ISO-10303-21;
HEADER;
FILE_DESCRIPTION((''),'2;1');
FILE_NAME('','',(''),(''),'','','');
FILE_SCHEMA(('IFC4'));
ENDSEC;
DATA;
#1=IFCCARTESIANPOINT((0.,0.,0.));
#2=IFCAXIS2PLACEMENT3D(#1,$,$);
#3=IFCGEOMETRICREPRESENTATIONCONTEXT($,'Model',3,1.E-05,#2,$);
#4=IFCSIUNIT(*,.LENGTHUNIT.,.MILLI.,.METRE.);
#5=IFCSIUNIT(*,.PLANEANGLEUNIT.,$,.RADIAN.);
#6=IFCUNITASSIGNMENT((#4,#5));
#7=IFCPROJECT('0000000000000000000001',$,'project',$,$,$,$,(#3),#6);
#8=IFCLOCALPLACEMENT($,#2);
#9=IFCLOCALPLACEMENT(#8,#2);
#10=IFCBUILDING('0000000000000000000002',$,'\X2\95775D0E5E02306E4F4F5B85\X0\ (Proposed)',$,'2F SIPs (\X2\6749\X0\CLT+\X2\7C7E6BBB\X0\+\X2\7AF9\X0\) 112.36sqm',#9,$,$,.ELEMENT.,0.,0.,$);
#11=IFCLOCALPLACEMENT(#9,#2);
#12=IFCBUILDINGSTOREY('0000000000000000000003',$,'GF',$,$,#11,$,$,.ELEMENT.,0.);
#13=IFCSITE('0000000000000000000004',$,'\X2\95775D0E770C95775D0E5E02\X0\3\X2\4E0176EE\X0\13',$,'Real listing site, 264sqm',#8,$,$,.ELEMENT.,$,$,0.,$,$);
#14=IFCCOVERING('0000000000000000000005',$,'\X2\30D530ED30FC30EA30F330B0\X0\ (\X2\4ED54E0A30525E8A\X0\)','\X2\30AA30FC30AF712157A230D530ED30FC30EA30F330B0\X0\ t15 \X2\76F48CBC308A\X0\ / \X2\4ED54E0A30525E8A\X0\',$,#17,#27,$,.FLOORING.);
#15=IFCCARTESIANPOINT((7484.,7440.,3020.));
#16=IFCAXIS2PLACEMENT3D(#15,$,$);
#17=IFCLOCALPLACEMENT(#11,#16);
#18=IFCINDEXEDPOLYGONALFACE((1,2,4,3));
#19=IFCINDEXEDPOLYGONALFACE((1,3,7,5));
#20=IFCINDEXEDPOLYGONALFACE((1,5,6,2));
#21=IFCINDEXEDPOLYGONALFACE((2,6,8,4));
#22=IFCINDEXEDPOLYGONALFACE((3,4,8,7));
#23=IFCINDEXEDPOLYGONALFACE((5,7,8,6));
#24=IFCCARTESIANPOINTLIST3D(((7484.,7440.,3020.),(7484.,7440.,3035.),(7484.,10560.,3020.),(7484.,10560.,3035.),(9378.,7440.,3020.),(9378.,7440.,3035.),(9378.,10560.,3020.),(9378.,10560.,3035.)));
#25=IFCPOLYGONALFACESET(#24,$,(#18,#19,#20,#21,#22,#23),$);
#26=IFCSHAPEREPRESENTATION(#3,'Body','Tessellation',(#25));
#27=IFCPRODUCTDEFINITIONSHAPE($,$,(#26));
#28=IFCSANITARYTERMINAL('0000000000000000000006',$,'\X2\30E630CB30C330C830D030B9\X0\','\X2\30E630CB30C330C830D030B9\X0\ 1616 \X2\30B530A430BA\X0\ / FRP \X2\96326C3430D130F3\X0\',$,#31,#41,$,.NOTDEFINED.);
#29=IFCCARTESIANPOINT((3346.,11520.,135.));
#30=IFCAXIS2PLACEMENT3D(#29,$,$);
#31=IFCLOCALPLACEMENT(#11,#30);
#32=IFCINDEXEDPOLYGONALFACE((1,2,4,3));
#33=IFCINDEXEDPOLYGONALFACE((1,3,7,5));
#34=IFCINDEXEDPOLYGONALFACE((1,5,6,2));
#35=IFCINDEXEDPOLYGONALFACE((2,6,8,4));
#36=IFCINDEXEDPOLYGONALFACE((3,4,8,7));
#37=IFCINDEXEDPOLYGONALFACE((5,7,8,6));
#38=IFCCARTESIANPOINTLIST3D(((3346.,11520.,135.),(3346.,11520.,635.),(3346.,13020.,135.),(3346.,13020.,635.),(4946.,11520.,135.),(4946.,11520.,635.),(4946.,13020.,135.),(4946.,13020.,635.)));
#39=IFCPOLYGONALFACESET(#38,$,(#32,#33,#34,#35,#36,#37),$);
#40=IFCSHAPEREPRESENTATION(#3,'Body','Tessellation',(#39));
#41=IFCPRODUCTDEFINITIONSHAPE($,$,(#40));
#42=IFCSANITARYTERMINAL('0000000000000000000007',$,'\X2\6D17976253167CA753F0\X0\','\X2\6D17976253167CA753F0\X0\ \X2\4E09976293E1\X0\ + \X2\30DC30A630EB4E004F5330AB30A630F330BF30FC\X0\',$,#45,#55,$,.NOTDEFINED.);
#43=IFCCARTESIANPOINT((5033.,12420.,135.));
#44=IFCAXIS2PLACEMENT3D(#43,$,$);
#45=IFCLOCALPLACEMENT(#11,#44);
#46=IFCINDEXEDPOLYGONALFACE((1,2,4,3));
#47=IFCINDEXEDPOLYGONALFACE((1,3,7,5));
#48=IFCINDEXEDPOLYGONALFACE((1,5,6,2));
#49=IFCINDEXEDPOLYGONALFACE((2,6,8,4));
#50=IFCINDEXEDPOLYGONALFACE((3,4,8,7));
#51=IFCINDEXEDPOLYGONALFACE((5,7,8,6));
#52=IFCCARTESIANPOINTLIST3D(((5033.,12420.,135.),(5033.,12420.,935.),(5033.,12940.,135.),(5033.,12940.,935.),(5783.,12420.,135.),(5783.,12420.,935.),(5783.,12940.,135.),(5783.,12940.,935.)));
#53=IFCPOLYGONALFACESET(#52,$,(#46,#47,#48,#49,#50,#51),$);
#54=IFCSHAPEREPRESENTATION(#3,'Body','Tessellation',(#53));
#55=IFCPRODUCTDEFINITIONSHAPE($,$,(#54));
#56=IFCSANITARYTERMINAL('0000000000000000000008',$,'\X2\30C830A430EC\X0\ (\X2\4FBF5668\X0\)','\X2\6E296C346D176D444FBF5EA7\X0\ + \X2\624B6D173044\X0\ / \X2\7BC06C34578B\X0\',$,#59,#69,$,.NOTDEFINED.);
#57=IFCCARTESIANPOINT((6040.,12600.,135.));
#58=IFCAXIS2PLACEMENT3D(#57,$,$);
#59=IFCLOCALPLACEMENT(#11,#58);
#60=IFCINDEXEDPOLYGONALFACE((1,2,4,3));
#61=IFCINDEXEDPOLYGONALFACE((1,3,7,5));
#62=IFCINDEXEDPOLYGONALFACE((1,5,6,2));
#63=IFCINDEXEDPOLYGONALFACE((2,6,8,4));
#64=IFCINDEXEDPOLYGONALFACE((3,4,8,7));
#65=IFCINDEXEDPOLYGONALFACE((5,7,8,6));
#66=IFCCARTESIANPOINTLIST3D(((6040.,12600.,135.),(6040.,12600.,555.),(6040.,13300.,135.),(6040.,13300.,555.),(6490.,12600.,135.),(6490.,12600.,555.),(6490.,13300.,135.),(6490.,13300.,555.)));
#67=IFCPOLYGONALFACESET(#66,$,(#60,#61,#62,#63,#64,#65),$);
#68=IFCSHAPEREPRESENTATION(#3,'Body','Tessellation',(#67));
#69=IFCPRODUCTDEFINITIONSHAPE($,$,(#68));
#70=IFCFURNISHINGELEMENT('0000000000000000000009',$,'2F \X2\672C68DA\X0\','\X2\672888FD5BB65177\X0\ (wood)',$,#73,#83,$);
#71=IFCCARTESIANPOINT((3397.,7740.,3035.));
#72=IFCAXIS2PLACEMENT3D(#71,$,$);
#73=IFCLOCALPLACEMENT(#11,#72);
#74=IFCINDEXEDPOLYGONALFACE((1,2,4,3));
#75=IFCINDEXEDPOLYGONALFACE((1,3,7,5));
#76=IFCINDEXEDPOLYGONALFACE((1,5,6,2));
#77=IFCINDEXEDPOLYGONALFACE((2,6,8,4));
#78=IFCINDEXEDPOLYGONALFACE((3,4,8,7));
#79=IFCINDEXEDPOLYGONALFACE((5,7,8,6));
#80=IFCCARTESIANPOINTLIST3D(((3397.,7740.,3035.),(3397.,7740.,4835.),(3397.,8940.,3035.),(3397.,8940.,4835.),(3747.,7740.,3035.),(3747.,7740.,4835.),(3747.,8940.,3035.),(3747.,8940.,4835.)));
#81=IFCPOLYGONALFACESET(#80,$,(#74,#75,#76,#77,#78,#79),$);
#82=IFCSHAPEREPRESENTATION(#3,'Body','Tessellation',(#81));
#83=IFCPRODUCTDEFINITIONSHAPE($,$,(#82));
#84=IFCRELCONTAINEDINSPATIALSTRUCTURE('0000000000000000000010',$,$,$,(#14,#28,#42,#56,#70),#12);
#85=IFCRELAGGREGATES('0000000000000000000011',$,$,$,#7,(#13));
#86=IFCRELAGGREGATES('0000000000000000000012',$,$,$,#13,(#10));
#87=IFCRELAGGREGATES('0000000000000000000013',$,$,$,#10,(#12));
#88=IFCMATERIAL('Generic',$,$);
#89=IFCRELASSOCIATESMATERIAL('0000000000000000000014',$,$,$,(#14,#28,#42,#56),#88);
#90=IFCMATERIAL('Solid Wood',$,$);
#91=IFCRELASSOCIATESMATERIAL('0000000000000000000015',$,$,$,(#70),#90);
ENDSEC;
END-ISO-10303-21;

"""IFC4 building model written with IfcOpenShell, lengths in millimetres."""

from ifc_helpers import new_model, si_unit, frame, frame_2d, origin, place, context, project, spatial, rectangle, extrude, material, element, save


model = new_model("IFC4")

# Units and contexts
model_context = context("Model", 3, precision=1e-05, world=origin())
ifc_project = project(units=[si_unit("LENGTHUNIT", "METRE", prefix="MILLI"), si_unit("PLANEANGLEUNIT", "RADIAN")], contexts=[model_context])

# Site, building, storey
site_placement = place(None, origin())
site = spatial("IfcSite", under=ifc_project, at=site_placement, Name="長崎県長崎市3丁目13", ObjectType="Real listing site, 264sqm", CompositionType="ELEMENT", RefElevation=0.0)
building_placement = place(site_placement, origin())
building = spatial("IfcBuilding", under=site, at=building_placement, Name="長崎市の住宅 (Proposed)", ObjectType="2F SIPs (杉CLT+籾殻+竹) 112.36sqm", CompositionType="ELEMENT", ElevationOfRefHeight=0.0, ElevationOfTerrain=0.0)
storey_placement = place(building_placement, origin())
storey = spatial("IfcBuildingStorey", under=building, at=storey_placement, Name="GF", CompositionType="ELEMENT", Elevation=0.0)

# Shared definitions
ifc_material_1 = material(Name="Solid Wood")

# Shared definitions
ifc_material_2 = material(Name="Generic")

# Covering
covering_1_placement = place(storey_placement, frame((7484.0, 7440.0, 3020.0)))
element("IfcCovering", 1, at=covering_1_placement, inside=storey, material=ifc_material_2, Name="フローリング (仕上げ床)", Description="オーク無垢フローリング t15 直貼り / 仕上げ床", PredefinedType="FLOORING", context=model_context, shape_type="SweptSolid", body=[
    extrude(rectangle(XDim=1894.0, YDim=3120.0, at=frame_2d((947.0, 1560.0))), frame((7484.0, 7440.0, 3020.0)), (0.0, 0.0, 1.0), 15.0),
])

# Sanitary terminals
sanitary_terminal_1_placement = place(storey_placement, frame((3346.0, 11520.0, 135.0)))
element("IfcSanitaryTerminal", 2, at=sanitary_terminal_1_placement, inside=storey, material=ifc_material_2, Name="ユニットバス", Description="ユニットバス 1616 サイズ / FRP 防水パン", PredefinedType="NOTDEFINED", context=model_context, shape_type="SweptSolid", body=[
    extrude(rectangle(XDim=1600.0, YDim=1500.0, at=frame_2d((800.0, 750.0))), frame((3346.0, 11520.0, 135.0)), (0.0, 0.0, 1.0), 500.0),
])
sanitary_terminal_2_placement = place(storey_placement, frame((5033.0, 12420.0, 135.0)))
element("IfcSanitaryTerminal", 3, at=sanitary_terminal_2_placement, inside=storey, material=ifc_material_2, Name="洗面化粧台", Description="洗面化粧台 三面鏡 + ボウル一体カウンター", PredefinedType="NOTDEFINED", context=model_context, shape_type="SweptSolid", body=[
    extrude(rectangle(XDim=750.0, YDim=520.0, at=frame_2d((375.0, 260.0))), frame((5033.0, 12420.0, 135.0)), (0.0, 0.0, 1.0), 800.0),
])
sanitary_terminal_3_placement = place(storey_placement, frame((6040.0, 12600.0, 135.0)))
element("IfcSanitaryTerminal", 4, at=sanitary_terminal_3_placement, inside=storey, material=ifc_material_2, Name="トイレ (便器)", Description="温水洗浄便座 + 手洗い / 節水型", PredefinedType="NOTDEFINED", context=model_context, shape_type="SweptSolid", body=[
    extrude(rectangle(XDim=450.0, YDim=700.0, at=frame_2d((225.0, 350.0))), frame((6040.0, 12600.0, 135.0)), (0.0, 0.0, 1.0), 420.0),
])

# Furnishing element
furnishing_placement = place(storey_placement, frame((3397.0, 7740.0, 3035.0)))
element("IfcFurnishingElement", 5, at=furnishing_placement, inside=storey, material=ifc_material_1, Name="2F 本棚", Description="木製家具 (wood)", context=model_context, shape_type="SweptSolid", body=[
    extrude(rectangle(XDim=350.0, YDim=1200.0, at=frame_2d((175.0, 600.0))), frame((3397.0, 7740.0, 3035.0)), (0.0, 0.0, 1.0), 1800.0),
])

save(model, "model.ifc")
